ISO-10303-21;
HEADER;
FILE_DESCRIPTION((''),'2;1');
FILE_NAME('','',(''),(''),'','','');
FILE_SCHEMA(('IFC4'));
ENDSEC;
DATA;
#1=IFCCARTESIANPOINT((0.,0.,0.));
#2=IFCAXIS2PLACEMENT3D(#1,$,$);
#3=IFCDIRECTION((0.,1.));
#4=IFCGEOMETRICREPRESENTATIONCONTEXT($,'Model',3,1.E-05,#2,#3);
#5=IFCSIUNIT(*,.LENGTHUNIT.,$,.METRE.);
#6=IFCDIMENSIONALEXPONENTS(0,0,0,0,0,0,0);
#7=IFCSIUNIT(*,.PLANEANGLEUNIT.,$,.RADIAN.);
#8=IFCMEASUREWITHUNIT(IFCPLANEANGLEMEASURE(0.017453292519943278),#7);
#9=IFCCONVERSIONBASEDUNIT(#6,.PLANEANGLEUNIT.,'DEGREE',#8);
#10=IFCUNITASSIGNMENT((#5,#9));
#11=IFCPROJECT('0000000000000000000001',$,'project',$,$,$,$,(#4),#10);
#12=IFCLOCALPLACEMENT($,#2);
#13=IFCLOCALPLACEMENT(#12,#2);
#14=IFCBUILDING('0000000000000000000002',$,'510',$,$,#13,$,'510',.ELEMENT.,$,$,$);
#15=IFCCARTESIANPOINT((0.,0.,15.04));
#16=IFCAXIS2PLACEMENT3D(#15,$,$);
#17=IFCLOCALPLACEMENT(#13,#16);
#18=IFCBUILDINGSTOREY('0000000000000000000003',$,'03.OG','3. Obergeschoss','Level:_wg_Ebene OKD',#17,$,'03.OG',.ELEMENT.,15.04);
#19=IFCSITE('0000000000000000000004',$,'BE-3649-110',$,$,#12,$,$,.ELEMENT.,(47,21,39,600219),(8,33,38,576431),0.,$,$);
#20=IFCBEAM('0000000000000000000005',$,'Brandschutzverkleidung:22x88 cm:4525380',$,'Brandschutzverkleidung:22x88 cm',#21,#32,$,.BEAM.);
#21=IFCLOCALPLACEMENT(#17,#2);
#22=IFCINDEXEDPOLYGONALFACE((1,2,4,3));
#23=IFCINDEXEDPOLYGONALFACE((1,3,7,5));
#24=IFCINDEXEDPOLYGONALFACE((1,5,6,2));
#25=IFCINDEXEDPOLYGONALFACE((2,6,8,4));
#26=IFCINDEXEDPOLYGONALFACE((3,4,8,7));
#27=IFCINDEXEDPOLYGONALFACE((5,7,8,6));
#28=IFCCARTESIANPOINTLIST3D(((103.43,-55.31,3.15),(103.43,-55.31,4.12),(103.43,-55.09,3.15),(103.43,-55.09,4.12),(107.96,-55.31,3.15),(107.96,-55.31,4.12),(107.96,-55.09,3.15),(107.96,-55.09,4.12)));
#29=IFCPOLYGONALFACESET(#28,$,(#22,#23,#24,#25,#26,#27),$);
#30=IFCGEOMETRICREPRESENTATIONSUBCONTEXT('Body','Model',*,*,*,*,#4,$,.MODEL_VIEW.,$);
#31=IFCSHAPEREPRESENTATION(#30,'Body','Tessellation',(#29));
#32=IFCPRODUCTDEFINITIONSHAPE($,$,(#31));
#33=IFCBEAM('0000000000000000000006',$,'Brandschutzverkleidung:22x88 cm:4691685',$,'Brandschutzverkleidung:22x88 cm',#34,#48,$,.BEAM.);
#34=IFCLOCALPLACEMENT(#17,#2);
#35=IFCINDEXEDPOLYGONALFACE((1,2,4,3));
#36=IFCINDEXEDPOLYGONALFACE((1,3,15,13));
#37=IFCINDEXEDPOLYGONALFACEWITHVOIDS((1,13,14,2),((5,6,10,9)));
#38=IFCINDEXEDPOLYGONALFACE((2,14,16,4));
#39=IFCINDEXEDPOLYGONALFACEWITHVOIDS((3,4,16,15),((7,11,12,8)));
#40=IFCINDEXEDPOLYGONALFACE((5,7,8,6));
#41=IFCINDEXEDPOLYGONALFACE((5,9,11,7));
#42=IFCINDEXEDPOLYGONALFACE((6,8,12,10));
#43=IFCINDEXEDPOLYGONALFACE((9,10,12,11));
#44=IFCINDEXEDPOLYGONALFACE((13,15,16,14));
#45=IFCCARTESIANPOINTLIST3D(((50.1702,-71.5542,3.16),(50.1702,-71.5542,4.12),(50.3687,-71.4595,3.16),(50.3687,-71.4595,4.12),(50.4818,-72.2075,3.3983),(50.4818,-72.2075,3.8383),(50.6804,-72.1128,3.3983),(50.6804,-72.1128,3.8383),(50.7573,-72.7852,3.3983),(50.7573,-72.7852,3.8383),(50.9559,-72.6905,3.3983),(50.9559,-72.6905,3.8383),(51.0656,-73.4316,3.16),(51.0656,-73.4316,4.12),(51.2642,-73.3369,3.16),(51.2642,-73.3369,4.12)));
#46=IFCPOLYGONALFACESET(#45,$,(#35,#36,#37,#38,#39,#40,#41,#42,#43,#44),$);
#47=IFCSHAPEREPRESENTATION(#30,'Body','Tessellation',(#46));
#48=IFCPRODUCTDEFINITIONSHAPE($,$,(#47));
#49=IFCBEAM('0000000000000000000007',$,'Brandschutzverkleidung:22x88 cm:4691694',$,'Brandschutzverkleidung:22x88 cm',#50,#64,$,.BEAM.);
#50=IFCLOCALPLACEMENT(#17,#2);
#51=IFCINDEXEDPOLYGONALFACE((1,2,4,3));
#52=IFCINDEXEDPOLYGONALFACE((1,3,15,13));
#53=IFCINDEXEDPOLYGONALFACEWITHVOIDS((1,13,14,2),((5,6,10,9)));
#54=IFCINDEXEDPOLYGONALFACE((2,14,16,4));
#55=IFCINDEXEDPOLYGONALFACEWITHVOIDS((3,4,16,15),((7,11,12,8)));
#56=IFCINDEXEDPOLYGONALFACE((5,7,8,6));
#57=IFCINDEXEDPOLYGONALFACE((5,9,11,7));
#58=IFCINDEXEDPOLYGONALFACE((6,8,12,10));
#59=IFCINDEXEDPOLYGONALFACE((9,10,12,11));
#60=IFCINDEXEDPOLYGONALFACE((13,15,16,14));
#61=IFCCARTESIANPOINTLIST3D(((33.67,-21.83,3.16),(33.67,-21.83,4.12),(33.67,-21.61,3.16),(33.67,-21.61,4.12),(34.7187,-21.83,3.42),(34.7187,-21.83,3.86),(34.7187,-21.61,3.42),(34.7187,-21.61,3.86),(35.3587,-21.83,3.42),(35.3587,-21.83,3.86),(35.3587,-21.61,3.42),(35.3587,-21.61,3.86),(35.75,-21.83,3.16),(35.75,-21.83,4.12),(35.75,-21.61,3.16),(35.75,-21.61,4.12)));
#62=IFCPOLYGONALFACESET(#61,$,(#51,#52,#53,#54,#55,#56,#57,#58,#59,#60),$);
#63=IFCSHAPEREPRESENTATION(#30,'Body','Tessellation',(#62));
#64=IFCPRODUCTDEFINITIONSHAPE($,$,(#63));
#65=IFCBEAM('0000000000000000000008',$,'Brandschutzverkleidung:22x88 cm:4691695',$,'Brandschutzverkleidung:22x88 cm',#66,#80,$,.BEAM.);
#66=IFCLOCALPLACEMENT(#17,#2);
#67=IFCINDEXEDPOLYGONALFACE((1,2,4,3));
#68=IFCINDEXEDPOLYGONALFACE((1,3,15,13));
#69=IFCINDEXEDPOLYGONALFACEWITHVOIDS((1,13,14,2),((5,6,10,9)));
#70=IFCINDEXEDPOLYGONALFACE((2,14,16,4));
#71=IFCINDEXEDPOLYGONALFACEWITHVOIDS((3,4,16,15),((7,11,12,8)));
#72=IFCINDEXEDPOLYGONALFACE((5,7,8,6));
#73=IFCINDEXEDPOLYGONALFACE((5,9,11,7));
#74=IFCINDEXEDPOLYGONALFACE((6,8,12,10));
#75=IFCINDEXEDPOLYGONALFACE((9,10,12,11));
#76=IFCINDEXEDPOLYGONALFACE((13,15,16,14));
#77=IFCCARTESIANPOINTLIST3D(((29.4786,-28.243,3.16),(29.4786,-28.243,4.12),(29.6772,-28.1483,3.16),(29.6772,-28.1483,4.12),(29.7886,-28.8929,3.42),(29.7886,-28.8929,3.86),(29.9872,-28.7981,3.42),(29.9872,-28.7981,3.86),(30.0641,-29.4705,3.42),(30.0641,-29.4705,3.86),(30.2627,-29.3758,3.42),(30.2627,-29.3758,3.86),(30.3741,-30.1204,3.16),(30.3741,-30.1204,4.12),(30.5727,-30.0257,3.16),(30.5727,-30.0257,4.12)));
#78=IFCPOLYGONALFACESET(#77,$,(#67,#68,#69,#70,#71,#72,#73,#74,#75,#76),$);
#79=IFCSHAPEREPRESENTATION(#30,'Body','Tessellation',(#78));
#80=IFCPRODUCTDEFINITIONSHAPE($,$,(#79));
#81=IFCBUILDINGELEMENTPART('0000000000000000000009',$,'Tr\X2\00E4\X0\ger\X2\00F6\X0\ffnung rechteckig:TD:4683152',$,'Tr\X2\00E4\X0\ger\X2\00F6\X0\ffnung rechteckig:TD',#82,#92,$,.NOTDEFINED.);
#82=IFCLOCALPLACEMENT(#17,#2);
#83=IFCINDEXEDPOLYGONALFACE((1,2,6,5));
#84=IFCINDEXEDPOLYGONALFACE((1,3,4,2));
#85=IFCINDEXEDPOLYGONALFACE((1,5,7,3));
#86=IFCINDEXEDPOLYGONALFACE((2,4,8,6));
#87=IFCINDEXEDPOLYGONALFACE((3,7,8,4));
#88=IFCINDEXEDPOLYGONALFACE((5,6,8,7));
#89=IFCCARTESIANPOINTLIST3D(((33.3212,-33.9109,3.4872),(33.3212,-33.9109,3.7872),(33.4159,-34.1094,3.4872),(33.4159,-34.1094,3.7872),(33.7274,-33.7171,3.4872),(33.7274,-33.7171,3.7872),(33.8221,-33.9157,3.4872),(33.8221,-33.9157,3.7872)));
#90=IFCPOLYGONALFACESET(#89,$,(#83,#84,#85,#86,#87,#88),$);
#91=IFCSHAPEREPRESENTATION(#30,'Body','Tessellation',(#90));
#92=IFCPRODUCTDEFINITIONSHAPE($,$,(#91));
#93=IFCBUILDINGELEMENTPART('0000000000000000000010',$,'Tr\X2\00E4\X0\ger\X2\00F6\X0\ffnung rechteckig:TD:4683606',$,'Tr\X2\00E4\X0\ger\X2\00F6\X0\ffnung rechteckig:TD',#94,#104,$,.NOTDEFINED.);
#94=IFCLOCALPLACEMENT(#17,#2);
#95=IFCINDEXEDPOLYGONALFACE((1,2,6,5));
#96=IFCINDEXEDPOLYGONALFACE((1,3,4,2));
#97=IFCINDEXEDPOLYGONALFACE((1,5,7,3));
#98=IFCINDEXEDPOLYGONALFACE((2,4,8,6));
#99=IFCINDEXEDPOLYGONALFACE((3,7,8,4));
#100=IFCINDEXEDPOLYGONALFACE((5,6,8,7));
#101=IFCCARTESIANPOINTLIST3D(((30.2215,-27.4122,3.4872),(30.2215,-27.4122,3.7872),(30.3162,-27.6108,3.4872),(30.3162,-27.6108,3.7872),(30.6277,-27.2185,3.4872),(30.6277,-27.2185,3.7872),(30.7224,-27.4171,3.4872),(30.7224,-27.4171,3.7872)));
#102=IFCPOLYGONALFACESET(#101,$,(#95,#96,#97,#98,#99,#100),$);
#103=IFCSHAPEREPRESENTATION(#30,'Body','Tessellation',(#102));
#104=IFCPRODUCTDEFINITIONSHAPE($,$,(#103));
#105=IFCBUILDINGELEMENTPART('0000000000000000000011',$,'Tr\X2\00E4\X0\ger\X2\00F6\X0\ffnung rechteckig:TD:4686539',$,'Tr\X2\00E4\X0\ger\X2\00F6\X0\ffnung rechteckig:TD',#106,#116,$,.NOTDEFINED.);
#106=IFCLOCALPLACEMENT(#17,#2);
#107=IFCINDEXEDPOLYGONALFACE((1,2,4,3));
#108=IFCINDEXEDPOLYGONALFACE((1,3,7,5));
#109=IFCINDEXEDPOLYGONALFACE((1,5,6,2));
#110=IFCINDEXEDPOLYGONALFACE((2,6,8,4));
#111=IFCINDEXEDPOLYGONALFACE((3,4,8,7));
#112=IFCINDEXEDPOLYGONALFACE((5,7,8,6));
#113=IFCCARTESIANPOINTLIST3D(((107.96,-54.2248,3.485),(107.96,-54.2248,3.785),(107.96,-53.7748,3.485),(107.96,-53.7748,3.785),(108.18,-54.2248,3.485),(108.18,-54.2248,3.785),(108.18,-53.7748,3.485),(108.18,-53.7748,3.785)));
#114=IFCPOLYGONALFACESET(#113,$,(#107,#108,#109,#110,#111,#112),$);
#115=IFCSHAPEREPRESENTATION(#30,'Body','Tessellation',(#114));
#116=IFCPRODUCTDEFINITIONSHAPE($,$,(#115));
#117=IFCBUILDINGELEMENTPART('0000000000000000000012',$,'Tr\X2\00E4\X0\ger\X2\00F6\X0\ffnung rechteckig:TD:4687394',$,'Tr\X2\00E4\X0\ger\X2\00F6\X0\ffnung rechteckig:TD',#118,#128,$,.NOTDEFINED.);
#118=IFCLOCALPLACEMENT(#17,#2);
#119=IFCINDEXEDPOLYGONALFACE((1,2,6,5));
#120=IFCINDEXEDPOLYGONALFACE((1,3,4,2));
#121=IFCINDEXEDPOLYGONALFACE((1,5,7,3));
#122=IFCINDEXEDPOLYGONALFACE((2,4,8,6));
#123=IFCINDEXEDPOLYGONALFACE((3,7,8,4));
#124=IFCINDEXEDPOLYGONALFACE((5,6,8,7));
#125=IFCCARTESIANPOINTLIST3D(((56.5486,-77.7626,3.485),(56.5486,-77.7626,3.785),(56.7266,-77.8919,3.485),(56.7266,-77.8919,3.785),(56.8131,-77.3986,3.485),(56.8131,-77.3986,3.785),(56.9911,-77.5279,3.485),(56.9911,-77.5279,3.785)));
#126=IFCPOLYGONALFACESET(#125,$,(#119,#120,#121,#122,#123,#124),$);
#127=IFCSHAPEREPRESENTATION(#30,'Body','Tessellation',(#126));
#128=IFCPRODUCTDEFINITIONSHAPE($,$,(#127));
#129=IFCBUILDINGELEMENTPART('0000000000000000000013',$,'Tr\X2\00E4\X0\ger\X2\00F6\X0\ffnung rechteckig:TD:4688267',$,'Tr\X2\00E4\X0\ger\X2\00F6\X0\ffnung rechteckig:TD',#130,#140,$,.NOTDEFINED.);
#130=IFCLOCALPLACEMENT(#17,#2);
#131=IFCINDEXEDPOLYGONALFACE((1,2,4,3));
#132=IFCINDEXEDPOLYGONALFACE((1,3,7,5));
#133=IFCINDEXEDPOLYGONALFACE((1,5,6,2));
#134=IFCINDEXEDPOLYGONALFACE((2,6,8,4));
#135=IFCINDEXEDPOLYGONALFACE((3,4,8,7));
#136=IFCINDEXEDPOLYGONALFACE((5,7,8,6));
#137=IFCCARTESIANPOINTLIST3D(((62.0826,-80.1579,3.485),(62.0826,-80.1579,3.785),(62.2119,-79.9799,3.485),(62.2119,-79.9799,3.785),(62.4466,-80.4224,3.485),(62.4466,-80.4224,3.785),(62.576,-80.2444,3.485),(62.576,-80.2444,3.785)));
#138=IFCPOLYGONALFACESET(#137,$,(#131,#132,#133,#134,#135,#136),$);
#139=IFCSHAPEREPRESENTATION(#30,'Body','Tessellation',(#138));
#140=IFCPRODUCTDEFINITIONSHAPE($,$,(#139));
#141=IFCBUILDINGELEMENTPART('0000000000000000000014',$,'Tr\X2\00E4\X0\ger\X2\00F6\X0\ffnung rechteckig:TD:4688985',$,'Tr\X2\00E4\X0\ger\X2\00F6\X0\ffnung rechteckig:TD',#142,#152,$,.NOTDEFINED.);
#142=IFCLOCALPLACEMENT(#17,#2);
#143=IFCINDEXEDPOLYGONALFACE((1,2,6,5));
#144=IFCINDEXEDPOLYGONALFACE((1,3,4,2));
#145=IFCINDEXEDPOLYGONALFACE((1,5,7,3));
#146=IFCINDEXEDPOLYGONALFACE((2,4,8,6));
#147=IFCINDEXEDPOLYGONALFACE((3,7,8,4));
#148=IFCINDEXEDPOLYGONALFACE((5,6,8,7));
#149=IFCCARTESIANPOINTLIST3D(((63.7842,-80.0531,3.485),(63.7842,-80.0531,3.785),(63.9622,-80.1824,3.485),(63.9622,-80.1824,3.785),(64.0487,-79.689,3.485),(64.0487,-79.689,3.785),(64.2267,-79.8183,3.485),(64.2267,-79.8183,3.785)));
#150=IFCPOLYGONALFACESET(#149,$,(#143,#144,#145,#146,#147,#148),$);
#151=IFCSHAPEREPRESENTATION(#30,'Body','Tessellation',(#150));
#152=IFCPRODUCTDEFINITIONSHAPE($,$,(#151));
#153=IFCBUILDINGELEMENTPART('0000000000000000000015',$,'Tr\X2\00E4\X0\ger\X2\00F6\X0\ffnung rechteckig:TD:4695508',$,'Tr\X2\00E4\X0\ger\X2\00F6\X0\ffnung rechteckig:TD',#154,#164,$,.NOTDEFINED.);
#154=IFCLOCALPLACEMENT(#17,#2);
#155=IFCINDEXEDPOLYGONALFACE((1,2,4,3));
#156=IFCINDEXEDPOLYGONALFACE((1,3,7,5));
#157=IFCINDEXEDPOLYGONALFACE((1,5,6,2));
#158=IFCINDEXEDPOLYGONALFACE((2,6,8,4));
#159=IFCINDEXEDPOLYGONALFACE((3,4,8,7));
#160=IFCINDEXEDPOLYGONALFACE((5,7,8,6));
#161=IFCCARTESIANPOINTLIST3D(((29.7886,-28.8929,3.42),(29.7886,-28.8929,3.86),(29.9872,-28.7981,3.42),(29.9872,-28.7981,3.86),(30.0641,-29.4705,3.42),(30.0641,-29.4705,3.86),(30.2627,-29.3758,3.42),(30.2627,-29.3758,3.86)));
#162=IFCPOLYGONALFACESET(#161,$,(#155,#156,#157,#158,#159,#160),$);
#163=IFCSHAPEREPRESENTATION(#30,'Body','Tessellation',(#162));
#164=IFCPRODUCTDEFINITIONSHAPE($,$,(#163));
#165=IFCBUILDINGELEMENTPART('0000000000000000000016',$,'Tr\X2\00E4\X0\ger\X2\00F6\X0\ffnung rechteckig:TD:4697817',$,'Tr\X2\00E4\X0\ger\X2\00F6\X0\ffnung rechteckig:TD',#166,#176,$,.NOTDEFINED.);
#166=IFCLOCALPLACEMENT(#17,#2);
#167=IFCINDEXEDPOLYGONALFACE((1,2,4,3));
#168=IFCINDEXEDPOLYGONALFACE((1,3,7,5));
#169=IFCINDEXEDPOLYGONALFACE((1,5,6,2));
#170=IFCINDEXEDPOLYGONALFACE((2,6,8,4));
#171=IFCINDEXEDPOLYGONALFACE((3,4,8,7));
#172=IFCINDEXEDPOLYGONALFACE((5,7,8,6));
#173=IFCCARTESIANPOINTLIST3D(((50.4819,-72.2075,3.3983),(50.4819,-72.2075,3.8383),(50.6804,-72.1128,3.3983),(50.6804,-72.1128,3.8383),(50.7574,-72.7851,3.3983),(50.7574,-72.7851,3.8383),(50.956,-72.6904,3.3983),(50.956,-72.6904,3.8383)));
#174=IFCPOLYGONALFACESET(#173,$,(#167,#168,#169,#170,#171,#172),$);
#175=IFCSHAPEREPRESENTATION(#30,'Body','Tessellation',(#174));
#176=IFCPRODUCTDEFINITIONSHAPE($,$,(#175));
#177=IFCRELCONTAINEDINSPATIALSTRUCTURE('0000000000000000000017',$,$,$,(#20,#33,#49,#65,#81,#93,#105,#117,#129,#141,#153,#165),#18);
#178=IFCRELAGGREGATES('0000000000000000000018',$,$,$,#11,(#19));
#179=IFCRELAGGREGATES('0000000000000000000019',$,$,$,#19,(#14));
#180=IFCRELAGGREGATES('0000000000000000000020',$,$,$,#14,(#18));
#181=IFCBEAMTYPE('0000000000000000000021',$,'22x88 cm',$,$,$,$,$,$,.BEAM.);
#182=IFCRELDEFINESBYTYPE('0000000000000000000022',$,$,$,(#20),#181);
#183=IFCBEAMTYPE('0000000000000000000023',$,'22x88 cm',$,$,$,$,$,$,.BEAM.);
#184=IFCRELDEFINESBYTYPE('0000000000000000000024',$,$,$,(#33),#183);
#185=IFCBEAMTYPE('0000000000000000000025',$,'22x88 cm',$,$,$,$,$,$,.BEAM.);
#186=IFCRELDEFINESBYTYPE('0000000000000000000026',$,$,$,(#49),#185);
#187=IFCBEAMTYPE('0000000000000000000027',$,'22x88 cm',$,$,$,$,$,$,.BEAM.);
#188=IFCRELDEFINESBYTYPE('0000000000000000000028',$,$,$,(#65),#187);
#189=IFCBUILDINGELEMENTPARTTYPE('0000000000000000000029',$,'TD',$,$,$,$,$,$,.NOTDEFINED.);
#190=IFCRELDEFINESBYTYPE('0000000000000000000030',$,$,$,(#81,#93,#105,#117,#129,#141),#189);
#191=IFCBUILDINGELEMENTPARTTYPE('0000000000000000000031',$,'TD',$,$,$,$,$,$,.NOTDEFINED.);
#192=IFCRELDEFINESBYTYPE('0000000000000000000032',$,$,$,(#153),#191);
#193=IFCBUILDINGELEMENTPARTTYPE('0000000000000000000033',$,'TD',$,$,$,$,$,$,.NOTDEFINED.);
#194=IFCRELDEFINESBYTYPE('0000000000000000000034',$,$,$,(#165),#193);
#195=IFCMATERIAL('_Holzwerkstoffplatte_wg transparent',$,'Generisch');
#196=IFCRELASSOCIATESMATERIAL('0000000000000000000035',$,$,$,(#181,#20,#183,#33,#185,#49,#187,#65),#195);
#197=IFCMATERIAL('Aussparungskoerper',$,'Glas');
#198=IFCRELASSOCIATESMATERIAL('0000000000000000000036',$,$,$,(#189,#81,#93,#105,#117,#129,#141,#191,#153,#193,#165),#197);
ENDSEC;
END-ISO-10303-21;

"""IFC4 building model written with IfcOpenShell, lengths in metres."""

from ifc_helpers import new_model, entity, si_unit, converted_unit, direction, frame, origin, place, context, subcontext, project, spatial, indexed_curve, outline, extrude, source, transform, mapped, material, type_object, type_shapes, element, save


model = new_model("IFC4")

# Units and contexts
model_context = context("Model", 3, precision=1e-05, world=origin(), true_north=direction((0.0, 1.0)))
body_context = subcontext(model_context, "Body", "Model", "MODEL_VIEW")
ifc_project = project(units=[si_unit("LENGTHUNIT", "METRE"), converted_unit("PLANEANGLEUNIT", "DEGREE", entity("IfcPlaneAngleMeasure", 0.017453292519943278), si_unit("PLANEANGLEUNIT", "RADIAN"), dimensions=[0, 0, 0, 0, 0, 0, 0])], contexts=[model_context])

# Site, building, storey
site_placement = place(None, origin())
site = spatial("IfcSite", under=ifc_project, at=site_placement, Name="BE-3649-110", CompositionType="ELEMENT", RefLatitude=(47, 21, 39, 600219), RefLongitude=(8, 33, 38, 576431), RefElevation=0.0)
building_placement = place(site_placement, origin())
building = spatial("IfcBuilding", under=site, at=building_placement, Name="510", LongName="510", CompositionType="ELEMENT")
storey_placement = place(building_placement, frame((0.0, 0.0, 15.04)))
storey = spatial("IfcBuildingStorey", under=building, at=storey_placement, Name="03.OG", Description="3. Obergeschoss", ObjectType="Level:_wg_Ebene OKD", LongName="03.OG", CompositionType="ELEMENT", Elevation=15.04)

# Shared definitions
ifc_material_1 = material(Name="_Holzwerkstoffplatte_wg transparent", Category="Generisch")

# Beam
beam_type_1 = type_object("IfcBeamType", Name="22x88 cm", PredefinedType="BEAM", material=ifc_material_1)
shared_shape_1 = source(origin(), body_context, "Body", "SweptSolid", [
    extrude(outline(indexed_curve([(-2.265, -0.11), (2.265, -0.11), (2.265, 0.11), (-2.265, 0.11), (-2.265, -0.11)], self_intersect=False)), frame((0.0, 0.0, -0.485)), (0.0, 0.0, 1.0), 0.97),
])
type_shapes(beam_type_1, [shared_shape_1])
beam_1_placement = place(storey_placement, frame((105.695, -55.2, 3.635)))
element("IfcBeam", 1, at=beam_1_placement, inside=storey, type_object=beam_type_1, material=ifc_material_1, Name="Brandschutzverkleidung:22x88 cm:4525380", ObjectType="Brandschutzverkleidung:22x88 cm", PredefinedType="BEAM", context=body_context, shape_type="MappedRepresentation", body=[
    mapped(shared_shape_1, transform((0.0, 0.0, 0.0), scale=1.0)),
])

# Beams
beam_type_2 = type_object("IfcBeamType", Name="22x88 cm", PredefinedType="BEAM", material=ifc_material_1)
shared_shape_2 = source(origin(), body_context, "Body", "SweptSolid", [
    extrude(outline(indexed_curve([(-1.04, -0.48), (1.04, -0.48), (1.04, 0.48), (-1.04, 0.48), (-1.04, -0.48)], self_intersect=False), holes=[indexed_curve([(0.3238, 0.2417), (0.3238, -0.1983), (-0.3162, -0.1983), (-0.3162, 0.2417), (0.3238, 0.2417)], self_intersect=False)]), frame((50.6179, -72.4929, 0.0), z_axis=(0.902585, 0.430511, 0.0), x_axis=(0.430511, -0.902585, 0.0)), (0.0, 0.0, 1.0), 0.22),
])
type_shapes(beam_type_2, [shared_shape_2])
beam_2_placement = place(storey_placement, frame((0.0, 0.0, 3.64)))
element("IfcBeam", 2, at=beam_2_placement, inside=storey, type_object=beam_type_2, material=ifc_material_1, Name="Brandschutzverkleidung:22x88 cm:4691685", ObjectType="Brandschutzverkleidung:22x88 cm", PredefinedType="BEAM", context=body_context, shape_type="MappedRepresentation", body=[
    mapped(shared_shape_2, transform((0.0, 0.0, 0.0), scale=1.0)),
])
beam_type_3 = type_object("IfcBeamType", Name="22x88 cm", PredefinedType="BEAM", material=ifc_material_1)
shared_shape_3 = source(origin(), body_context, "Body", "SweptSolid", [
    extrude(outline(indexed_curve([(-1.04, -0.48), (1.04, -0.48), (1.04, 0.48), (-1.04, 0.48), (-1.04, -0.48)], self_intersect=False), holes=[indexed_curve([(0.6487, 0.22), (0.6487, -0.22), (0.0087, -0.22), (0.0087, 0.22), (0.6487, 0.22)], self_intersect=False)]), frame((34.71, -21.83, 0.0), z_axis=(0.0, 1.0, 0.0), x_axis=(1.0, 0.0, 0.0)), (0.0, 0.0, 1.0), 0.22),
])
type_shapes(beam_type_3, [shared_shape_3])
beam_3_placement = place(storey_placement, frame((0.0, 0.0, 3.64)))
element("IfcBeam", 3, at=beam_3_placement, inside=storey, type_object=beam_type_3, material=ifc_material_1, Name="Brandschutzverkleidung:22x88 cm:4691694", ObjectType="Brandschutzverkleidung:22x88 cm", PredefinedType="BEAM", context=body_context, shape_type="MappedRepresentation", body=[
    mapped(shared_shape_3, transform((0.0, 0.0, 0.0), scale=1.0)),
])
beam_type_4 = type_object("IfcBeamType", Name="22x88 cm", PredefinedType="BEAM", material=ifc_material_1)
shared_shape_4 = source(origin(), body_context, "Body", "SweptSolid", [
    extrude(outline(indexed_curve([(-1.04, -0.48), (1.04, -0.48), (1.04, 0.48), (-1.04, 0.48), (-1.04, -0.48)], self_intersect=False), holes=[indexed_curve([(-0.32, -0.22), (-0.32, 0.22), (0.32, 0.22), (0.32, -0.22), (-0.32, -0.22)], self_intersect=False)]), frame((29.9264, -29.1817, 0.0), z_axis=(0.902585, 0.430511, 0.0), x_axis=(-0.430511, 0.902585, 0.0)), (0.0, 0.0, 1.0), 0.22),
])
type_shapes(beam_type_4, [shared_shape_4])
beam_4_placement = place(storey_placement, frame((0.0, 0.0, 3.64)))
element("IfcBeam", 4, at=beam_4_placement, inside=storey, type_object=beam_type_4, material=ifc_material_1, Name="Brandschutzverkleidung:22x88 cm:4691695", ObjectType="Brandschutzverkleidung:22x88 cm", PredefinedType="BEAM", context=body_context, shape_type="MappedRepresentation", body=[
    mapped(shared_shape_4, transform((0.0, 0.0, 0.0), scale=1.0)),
])

# Building element parts
ifc_material_2 = material(Name="Aussparungskoerper", Category="Glas")
building_element_part_type_1 = type_object("IfcBuildingElementPartType", Name="TD", PredefinedType="NOTDEFINED", material=ifc_material_2)
shared_shape_5 = source(origin(), body_context, "Body", "SweptSolid", [
    extrude(outline(indexed_curve([(-0.225, -0.15), (0.225, -0.15), (0.225, 0.15), (-0.225, 0.15), (-0.225, -0.15)], self_intersect=False)), frame((0.0, 0.0, -0.22), z_axis=(0.0, 0.0, 1.0), x_axis=(-1.0, 0.0, 0.0)), (0.0, 0.0, 1.0), 0.22),
])
type_shapes(building_element_part_type_1, [shared_shape_5])
for number, where, z_axis, x_axis, name in (
    (5, (33.619, -34.0126, 3.6372), (0.430511, -0.902585, 0.0), (-0.902585, -0.430511, 0.0), "Trägeröffnung rechteckig:TD:4683152"),
    (6, (30.5193, -27.5139, 3.6372), (0.430511, -0.902585, 0.0), (-0.902585, -0.430511, 0.0), "Trägeröffnung rechteckig:TD:4683606"),
    (7, (107.96, -53.9998, 3.635), (-1.0, 0.0, 0.0), (0.0, -1.0, 0.0), "Trägeröffnung rechteckig:TD:4686539"),
    (8, (56.8588, -77.7099, 3.635), (0.809017, -0.587785, 0.0), (-0.587785, -0.809017, 0.0), "Trägeröffnung rechteckig:TD:4687394"),
    (9, (62.2646, -80.2901, 3.635), (-0.587785, -0.809017, 0.0), (0.809017, -0.587785, 0.0), "Trägeröffnung rechteckig:TD:4688267"),
    (10, (64.0944, -80.0003, 3.635), (0.809017, -0.587785, 0.0), (-0.587785, -0.809017, 0.0), "Trägeröffnung rechteckig:TD:4688985"),
):
    element("IfcBuildingElementPart", number, at=place(storey_placement, frame(where, z_axis=z_axis, x_axis=x_axis)), inside=storey, type_object=building_element_part_type_1, material=ifc_material_2, Name=name, ObjectType="Trägeröffnung rechteckig:TD", PredefinedType="NOTDEFINED", context=body_context, shape_type="MappedRepresentation", body=[
        mapped(shared_shape_5, transform((0.0, 0.0, 0.0), scale=1.0)),
    ])
building_element_part_type_2 = type_object("IfcBuildingElementPartType", Name="TD", PredefinedType="NOTDEFINED", material=ifc_material_2)
shared_shape_6 = source(origin(), body_context, "Body", "SweptSolid", [
    extrude(outline(indexed_curve([(-0.11, -0.32), (0.11, -0.32), (0.11, 0.32), (-0.11, 0.32), (-0.11, -0.32)], self_intersect=False)), frame((30.0256, -29.1343, -0.44), z_axis=(0.0, 0.0, 1.0), x_axis=(-0.902585, -0.430511, 0.0)), (0.0, 0.0, 1.0), 0.44),
])
type_shapes(building_element_part_type_2, [shared_shape_6])
building_element_part_1_placement = place(storey_placement, frame((0.0, 0.0, 3.86)))
element("IfcBuildingElementPart", 11, at=building_element_part_1_placement, inside=storey, type_object=building_element_part_type_2, material=ifc_material_2, Name="Trägeröffnung rechteckig:TD:4695508", ObjectType="Trägeröffnung rechteckig:TD", PredefinedType="NOTDEFINED", context=body_context, shape_type="MappedRepresentation", body=[
    mapped(shared_shape_6, transform((0.0, 0.0, 0.0), scale=1.0)),
])
building_element_part_type_3 = type_object("IfcBuildingElementPartType", Name="TD", PredefinedType="NOTDEFINED", material=ifc_material_2)
shared_shape_7 = source(origin(), body_context, "Body", "SweptSolid", [
    extrude(outline(indexed_curve([(-0.11, -0.32), (0.11, -0.32), (0.11, 0.32), (-0.11, 0.32), (-0.11, -0.32)], self_intersect=False)), frame((50.7189, -72.449, -0.44), z_axis=(0.0, 0.0, 1.0), x_axis=(0.902586, 0.43051, 0.0)), (0.0, 0.0, 1.0), 0.44),
])
type_shapes(building_element_part_type_3, [shared_shape_7])
building_element_part_2_placement = place(storey_placement, frame((0.0, 0.0, 3.8383)))
element("IfcBuildingElementPart", 12, at=building_element_part_2_placement, inside=storey, type_object=building_element_part_type_3, material=ifc_material_2, Name="Trägeröffnung rechteckig:TD:4697817", ObjectType="Trägeröffnung rechteckig:TD", PredefinedType="NOTDEFINED", context=body_context, shape_type="MappedRepresentation", body=[
    mapped(shared_shape_7, transform((0.0, 0.0, 0.0), scale=1.0)),
])

save(model, "model.ifc")
